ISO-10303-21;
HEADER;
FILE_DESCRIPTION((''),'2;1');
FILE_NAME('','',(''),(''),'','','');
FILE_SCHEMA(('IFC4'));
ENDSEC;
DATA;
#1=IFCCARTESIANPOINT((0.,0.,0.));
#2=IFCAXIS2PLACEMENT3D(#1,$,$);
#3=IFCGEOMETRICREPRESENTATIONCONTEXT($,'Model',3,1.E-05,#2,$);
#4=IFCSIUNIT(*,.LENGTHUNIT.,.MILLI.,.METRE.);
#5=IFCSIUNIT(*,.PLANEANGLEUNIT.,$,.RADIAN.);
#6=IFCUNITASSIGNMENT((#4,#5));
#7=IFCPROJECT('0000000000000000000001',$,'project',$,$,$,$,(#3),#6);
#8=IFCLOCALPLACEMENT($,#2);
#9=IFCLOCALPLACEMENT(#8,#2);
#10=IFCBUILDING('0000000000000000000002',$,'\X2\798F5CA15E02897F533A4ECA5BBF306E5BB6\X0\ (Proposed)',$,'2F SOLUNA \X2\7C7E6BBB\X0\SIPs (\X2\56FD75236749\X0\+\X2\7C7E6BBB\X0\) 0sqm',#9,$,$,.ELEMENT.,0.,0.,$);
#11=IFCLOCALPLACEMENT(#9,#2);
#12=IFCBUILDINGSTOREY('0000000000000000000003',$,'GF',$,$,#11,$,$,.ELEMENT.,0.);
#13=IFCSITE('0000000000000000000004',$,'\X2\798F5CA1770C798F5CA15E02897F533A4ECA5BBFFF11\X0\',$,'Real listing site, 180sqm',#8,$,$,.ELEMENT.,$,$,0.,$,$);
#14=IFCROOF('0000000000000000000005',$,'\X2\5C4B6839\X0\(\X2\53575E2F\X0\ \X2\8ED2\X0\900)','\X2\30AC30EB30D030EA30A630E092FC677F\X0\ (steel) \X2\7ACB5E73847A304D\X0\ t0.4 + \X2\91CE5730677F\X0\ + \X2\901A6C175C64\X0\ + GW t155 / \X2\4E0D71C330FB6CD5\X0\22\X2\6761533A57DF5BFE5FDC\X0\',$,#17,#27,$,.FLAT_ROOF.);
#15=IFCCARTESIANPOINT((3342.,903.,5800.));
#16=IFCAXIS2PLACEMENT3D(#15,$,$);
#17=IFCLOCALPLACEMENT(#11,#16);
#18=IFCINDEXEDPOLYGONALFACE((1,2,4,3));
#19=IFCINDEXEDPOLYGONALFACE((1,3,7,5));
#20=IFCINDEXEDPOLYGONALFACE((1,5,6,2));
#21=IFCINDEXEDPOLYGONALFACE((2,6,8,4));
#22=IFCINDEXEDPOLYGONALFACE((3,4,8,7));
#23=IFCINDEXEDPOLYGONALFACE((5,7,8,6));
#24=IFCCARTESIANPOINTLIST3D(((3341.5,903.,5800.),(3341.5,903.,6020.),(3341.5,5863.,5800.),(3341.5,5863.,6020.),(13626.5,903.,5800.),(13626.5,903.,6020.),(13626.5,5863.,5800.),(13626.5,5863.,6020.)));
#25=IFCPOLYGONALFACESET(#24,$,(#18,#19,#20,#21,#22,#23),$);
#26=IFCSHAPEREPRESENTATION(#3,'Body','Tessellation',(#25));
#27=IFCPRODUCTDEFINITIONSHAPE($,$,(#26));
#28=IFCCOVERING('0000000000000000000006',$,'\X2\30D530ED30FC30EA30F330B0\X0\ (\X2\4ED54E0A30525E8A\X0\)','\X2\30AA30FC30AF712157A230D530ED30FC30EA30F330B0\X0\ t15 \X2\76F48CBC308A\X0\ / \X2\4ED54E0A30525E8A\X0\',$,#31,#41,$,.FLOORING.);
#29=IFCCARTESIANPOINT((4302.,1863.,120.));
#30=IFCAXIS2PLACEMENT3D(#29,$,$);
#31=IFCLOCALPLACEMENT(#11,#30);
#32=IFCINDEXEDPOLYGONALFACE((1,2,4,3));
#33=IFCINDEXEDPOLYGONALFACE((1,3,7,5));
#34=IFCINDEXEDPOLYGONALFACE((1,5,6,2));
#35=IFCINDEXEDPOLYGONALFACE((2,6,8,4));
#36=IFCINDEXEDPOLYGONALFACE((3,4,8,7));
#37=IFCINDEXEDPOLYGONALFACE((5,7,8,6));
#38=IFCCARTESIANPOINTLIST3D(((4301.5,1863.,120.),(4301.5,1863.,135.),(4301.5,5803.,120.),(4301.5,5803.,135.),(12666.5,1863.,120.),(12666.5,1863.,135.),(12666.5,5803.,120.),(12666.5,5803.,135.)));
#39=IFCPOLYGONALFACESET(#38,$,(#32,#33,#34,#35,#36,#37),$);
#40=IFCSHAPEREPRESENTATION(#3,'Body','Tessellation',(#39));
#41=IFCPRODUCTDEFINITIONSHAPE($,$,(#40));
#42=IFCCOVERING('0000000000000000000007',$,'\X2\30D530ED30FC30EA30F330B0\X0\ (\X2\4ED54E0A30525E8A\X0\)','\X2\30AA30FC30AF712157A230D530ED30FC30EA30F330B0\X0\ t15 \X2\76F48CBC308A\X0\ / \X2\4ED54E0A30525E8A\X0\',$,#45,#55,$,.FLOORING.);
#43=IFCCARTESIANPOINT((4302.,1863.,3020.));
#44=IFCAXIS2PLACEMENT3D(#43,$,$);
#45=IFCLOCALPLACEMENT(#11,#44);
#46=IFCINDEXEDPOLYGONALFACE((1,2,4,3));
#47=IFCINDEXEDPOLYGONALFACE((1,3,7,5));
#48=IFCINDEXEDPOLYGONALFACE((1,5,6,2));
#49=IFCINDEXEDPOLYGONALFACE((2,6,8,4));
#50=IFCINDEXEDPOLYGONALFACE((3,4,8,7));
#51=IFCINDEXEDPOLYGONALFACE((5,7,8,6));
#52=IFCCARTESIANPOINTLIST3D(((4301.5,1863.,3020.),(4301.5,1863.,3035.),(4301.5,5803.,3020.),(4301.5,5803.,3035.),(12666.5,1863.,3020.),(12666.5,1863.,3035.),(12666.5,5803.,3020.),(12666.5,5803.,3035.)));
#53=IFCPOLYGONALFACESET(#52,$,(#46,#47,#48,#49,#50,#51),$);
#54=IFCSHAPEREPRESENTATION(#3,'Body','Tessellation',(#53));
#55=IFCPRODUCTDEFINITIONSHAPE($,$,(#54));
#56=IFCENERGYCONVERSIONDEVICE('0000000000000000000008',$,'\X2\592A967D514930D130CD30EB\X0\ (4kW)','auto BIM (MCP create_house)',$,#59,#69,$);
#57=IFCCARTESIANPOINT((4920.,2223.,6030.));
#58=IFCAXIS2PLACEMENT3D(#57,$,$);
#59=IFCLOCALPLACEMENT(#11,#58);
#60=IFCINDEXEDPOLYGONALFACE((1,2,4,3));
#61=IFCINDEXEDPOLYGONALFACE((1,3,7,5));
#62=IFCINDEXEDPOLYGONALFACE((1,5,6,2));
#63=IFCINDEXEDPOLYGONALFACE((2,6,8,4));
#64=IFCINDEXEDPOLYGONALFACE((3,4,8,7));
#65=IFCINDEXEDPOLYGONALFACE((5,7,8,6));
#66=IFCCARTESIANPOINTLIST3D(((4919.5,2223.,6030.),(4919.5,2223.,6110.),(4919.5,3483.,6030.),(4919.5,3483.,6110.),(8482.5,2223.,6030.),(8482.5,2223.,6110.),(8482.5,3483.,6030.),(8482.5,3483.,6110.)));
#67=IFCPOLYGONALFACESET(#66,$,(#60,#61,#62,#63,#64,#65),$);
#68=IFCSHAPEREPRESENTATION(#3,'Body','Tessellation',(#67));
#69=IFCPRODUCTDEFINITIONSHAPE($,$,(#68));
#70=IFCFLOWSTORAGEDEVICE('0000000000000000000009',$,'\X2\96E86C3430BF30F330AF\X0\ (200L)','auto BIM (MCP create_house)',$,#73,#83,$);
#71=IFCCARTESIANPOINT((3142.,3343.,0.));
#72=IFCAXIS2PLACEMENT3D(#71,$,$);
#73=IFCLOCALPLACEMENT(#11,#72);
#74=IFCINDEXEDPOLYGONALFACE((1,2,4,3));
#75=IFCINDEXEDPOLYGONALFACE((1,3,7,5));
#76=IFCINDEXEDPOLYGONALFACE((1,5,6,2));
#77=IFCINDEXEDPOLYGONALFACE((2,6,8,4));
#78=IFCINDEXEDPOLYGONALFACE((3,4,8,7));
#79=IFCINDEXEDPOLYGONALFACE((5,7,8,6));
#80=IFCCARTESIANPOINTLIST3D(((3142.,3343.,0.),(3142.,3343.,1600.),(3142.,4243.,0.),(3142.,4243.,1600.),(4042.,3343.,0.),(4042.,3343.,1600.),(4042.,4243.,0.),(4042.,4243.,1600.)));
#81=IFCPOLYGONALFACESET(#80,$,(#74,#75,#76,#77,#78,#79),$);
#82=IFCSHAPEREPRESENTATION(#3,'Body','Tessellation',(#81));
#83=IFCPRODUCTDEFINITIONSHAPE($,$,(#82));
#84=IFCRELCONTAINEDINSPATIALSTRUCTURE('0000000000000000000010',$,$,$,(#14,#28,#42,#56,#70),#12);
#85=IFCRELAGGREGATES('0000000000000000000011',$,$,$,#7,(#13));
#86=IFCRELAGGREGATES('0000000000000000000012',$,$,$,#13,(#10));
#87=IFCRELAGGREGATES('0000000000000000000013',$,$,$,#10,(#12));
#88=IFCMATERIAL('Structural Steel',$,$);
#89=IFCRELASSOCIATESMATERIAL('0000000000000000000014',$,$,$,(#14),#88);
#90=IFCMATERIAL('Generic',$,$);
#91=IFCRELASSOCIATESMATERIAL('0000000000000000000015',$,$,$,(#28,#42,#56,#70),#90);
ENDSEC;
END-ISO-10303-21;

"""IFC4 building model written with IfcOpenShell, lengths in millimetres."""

from ifc_helpers import new_model, si_unit, frame, frame_2d, origin, place, context, project, spatial, rectangle, extrude, material, element, save


model = new_model("IFC4")

# Units and contexts
model_context = context("Model", 3, precision=1e-05, world=origin())
ifc_project = project(units=[si_unit("LENGTHUNIT", "METRE", prefix="MILLI"), si_unit("PLANEANGLEUNIT", "RADIAN")], contexts=[model_context])

# Site, building, storey
site_placement = place(None, origin())
site = spatial("IfcSite", under=ifc_project, at=site_placement, Name="福岡県福岡市西区今宿１", ObjectType="Real listing site, 180sqm", CompositionType="ELEMENT", RefElevation=0.0)
building_placement = place(site_placement, origin())
building = spatial("IfcBuilding", under=site, at=building_placement, Name="福岡市西区今宿の家 (Proposed)", ObjectType="2F SOLUNA 籾殻SIPs (国産杉+籾殻) 0sqm", CompositionType="ELEMENT", ElevationOfRefHeight=0.0, ElevationOfTerrain=0.0)
storey_placement = place(building_placement, origin())
storey = spatial("IfcBuildingStorey", under=building, at=storey_placement, Name="GF", CompositionType="ELEMENT", Elevation=0.0)

# Roof
ifc_material_1 = material(Name="Structural Steel")
for number, where, name in (
    (1, (3342.0, 903.0, 5800.0), "屋根(南帯 軒900)"),
):
    element("IfcRoof", number, at=place(storey_placement, frame(where)), inside=storey, material=ifc_material_1, Name=name, Description="ガルバリウム鋼板 (steel) 立平葺き t0.4 + 野地板 + 通気層 + GW t155 / 不燃・法22条区域対応", PredefinedType="FLAT_ROOF", context=model_context, shape_type="SweptSolid", body=[
        extrude(rectangle(XDim=10285.0, YDim=4960.0, at=frame_2d((5142.0, 2480.0))), frame((3342.0, 903.0, 5800.0)), (0.0, 0.0, 1.0), 220.0),
    ])

# Coverings
ifc_material_2 = material(Name="Generic")
covering_1_placement = place(storey_placement, frame((4302.0, 1863.0, 120.0)))
element("IfcCovering", 2, at=covering_1_placement, inside=storey, material=ifc_material_2, Name="フローリング (仕上げ床)", Description="オーク無垢フローリング t15 直貼り / 仕上げ床", PredefinedType="FLOORING", context=model_context, shape_type="SweptSolid", body=[
    extrude(rectangle(XDim=8365.0, YDim=3940.0, at=frame_2d((4182.0, 1970.0))), frame((4302.0, 1863.0, 120.0)), (0.0, 0.0, 1.0), 15.0),
])
covering_2_placement = place(storey_placement, frame((4302.0, 1863.0, 3020.0)))
element("IfcCovering", 3, at=covering_2_placement, inside=storey, material=ifc_material_2, Name="フローリング (仕上げ床)", Description="オーク無垢フローリング t15 直貼り / 仕上げ床", PredefinedType="FLOORING", context=model_context, shape_type="SweptSolid", body=[
    extrude(rectangle(XDim=8365.0, YDim=3940.0, at=frame_2d((4182.0, 1970.0))), frame((4302.0, 1863.0, 3020.0)), (0.0, 0.0, 1.0), 15.0),
])

# Energy conversion device
energy_conversion_device_placement = place(storey_placement, frame((4920.0, 2223.0, 6030.0)))
element("IfcEnergyConversionDevice", 4, at=energy_conversion_device_placement, inside=storey, material=ifc_material_2, Name="太陽光パネル (4kW)", Description="auto BIM (MCP create_house)", context=model_context, shape_type="SweptSolid", body=[
    extrude(rectangle(XDim=3563.0, YDim=1260.0, at=frame_2d((1781.0, 630.0))), frame((4920.0, 2223.0, 6030.0)), (0.0, 0.0, 1.0), 80.0),
])

# Flow storage device
flow_storage_device_placement = place(storey_placement, frame((3142.0, 3343.0, 0.0)))
element("IfcFlowStorageDevice", 5, at=flow_storage_device_placement, inside=storey, material=ifc_material_2, Name="雨水タンク (200L)", Description="auto BIM (MCP create_house)", context=model_context, shape_type="SweptSolid", body=[
    extrude(rectangle(XDim=900.0, YDim=900.0, at=frame_2d((450.0, 450.0))), frame((3142.0, 3343.0, 0.0)), (0.0, 0.0, 1.0), 1600.0),
])

save(model, "model.ifc")
